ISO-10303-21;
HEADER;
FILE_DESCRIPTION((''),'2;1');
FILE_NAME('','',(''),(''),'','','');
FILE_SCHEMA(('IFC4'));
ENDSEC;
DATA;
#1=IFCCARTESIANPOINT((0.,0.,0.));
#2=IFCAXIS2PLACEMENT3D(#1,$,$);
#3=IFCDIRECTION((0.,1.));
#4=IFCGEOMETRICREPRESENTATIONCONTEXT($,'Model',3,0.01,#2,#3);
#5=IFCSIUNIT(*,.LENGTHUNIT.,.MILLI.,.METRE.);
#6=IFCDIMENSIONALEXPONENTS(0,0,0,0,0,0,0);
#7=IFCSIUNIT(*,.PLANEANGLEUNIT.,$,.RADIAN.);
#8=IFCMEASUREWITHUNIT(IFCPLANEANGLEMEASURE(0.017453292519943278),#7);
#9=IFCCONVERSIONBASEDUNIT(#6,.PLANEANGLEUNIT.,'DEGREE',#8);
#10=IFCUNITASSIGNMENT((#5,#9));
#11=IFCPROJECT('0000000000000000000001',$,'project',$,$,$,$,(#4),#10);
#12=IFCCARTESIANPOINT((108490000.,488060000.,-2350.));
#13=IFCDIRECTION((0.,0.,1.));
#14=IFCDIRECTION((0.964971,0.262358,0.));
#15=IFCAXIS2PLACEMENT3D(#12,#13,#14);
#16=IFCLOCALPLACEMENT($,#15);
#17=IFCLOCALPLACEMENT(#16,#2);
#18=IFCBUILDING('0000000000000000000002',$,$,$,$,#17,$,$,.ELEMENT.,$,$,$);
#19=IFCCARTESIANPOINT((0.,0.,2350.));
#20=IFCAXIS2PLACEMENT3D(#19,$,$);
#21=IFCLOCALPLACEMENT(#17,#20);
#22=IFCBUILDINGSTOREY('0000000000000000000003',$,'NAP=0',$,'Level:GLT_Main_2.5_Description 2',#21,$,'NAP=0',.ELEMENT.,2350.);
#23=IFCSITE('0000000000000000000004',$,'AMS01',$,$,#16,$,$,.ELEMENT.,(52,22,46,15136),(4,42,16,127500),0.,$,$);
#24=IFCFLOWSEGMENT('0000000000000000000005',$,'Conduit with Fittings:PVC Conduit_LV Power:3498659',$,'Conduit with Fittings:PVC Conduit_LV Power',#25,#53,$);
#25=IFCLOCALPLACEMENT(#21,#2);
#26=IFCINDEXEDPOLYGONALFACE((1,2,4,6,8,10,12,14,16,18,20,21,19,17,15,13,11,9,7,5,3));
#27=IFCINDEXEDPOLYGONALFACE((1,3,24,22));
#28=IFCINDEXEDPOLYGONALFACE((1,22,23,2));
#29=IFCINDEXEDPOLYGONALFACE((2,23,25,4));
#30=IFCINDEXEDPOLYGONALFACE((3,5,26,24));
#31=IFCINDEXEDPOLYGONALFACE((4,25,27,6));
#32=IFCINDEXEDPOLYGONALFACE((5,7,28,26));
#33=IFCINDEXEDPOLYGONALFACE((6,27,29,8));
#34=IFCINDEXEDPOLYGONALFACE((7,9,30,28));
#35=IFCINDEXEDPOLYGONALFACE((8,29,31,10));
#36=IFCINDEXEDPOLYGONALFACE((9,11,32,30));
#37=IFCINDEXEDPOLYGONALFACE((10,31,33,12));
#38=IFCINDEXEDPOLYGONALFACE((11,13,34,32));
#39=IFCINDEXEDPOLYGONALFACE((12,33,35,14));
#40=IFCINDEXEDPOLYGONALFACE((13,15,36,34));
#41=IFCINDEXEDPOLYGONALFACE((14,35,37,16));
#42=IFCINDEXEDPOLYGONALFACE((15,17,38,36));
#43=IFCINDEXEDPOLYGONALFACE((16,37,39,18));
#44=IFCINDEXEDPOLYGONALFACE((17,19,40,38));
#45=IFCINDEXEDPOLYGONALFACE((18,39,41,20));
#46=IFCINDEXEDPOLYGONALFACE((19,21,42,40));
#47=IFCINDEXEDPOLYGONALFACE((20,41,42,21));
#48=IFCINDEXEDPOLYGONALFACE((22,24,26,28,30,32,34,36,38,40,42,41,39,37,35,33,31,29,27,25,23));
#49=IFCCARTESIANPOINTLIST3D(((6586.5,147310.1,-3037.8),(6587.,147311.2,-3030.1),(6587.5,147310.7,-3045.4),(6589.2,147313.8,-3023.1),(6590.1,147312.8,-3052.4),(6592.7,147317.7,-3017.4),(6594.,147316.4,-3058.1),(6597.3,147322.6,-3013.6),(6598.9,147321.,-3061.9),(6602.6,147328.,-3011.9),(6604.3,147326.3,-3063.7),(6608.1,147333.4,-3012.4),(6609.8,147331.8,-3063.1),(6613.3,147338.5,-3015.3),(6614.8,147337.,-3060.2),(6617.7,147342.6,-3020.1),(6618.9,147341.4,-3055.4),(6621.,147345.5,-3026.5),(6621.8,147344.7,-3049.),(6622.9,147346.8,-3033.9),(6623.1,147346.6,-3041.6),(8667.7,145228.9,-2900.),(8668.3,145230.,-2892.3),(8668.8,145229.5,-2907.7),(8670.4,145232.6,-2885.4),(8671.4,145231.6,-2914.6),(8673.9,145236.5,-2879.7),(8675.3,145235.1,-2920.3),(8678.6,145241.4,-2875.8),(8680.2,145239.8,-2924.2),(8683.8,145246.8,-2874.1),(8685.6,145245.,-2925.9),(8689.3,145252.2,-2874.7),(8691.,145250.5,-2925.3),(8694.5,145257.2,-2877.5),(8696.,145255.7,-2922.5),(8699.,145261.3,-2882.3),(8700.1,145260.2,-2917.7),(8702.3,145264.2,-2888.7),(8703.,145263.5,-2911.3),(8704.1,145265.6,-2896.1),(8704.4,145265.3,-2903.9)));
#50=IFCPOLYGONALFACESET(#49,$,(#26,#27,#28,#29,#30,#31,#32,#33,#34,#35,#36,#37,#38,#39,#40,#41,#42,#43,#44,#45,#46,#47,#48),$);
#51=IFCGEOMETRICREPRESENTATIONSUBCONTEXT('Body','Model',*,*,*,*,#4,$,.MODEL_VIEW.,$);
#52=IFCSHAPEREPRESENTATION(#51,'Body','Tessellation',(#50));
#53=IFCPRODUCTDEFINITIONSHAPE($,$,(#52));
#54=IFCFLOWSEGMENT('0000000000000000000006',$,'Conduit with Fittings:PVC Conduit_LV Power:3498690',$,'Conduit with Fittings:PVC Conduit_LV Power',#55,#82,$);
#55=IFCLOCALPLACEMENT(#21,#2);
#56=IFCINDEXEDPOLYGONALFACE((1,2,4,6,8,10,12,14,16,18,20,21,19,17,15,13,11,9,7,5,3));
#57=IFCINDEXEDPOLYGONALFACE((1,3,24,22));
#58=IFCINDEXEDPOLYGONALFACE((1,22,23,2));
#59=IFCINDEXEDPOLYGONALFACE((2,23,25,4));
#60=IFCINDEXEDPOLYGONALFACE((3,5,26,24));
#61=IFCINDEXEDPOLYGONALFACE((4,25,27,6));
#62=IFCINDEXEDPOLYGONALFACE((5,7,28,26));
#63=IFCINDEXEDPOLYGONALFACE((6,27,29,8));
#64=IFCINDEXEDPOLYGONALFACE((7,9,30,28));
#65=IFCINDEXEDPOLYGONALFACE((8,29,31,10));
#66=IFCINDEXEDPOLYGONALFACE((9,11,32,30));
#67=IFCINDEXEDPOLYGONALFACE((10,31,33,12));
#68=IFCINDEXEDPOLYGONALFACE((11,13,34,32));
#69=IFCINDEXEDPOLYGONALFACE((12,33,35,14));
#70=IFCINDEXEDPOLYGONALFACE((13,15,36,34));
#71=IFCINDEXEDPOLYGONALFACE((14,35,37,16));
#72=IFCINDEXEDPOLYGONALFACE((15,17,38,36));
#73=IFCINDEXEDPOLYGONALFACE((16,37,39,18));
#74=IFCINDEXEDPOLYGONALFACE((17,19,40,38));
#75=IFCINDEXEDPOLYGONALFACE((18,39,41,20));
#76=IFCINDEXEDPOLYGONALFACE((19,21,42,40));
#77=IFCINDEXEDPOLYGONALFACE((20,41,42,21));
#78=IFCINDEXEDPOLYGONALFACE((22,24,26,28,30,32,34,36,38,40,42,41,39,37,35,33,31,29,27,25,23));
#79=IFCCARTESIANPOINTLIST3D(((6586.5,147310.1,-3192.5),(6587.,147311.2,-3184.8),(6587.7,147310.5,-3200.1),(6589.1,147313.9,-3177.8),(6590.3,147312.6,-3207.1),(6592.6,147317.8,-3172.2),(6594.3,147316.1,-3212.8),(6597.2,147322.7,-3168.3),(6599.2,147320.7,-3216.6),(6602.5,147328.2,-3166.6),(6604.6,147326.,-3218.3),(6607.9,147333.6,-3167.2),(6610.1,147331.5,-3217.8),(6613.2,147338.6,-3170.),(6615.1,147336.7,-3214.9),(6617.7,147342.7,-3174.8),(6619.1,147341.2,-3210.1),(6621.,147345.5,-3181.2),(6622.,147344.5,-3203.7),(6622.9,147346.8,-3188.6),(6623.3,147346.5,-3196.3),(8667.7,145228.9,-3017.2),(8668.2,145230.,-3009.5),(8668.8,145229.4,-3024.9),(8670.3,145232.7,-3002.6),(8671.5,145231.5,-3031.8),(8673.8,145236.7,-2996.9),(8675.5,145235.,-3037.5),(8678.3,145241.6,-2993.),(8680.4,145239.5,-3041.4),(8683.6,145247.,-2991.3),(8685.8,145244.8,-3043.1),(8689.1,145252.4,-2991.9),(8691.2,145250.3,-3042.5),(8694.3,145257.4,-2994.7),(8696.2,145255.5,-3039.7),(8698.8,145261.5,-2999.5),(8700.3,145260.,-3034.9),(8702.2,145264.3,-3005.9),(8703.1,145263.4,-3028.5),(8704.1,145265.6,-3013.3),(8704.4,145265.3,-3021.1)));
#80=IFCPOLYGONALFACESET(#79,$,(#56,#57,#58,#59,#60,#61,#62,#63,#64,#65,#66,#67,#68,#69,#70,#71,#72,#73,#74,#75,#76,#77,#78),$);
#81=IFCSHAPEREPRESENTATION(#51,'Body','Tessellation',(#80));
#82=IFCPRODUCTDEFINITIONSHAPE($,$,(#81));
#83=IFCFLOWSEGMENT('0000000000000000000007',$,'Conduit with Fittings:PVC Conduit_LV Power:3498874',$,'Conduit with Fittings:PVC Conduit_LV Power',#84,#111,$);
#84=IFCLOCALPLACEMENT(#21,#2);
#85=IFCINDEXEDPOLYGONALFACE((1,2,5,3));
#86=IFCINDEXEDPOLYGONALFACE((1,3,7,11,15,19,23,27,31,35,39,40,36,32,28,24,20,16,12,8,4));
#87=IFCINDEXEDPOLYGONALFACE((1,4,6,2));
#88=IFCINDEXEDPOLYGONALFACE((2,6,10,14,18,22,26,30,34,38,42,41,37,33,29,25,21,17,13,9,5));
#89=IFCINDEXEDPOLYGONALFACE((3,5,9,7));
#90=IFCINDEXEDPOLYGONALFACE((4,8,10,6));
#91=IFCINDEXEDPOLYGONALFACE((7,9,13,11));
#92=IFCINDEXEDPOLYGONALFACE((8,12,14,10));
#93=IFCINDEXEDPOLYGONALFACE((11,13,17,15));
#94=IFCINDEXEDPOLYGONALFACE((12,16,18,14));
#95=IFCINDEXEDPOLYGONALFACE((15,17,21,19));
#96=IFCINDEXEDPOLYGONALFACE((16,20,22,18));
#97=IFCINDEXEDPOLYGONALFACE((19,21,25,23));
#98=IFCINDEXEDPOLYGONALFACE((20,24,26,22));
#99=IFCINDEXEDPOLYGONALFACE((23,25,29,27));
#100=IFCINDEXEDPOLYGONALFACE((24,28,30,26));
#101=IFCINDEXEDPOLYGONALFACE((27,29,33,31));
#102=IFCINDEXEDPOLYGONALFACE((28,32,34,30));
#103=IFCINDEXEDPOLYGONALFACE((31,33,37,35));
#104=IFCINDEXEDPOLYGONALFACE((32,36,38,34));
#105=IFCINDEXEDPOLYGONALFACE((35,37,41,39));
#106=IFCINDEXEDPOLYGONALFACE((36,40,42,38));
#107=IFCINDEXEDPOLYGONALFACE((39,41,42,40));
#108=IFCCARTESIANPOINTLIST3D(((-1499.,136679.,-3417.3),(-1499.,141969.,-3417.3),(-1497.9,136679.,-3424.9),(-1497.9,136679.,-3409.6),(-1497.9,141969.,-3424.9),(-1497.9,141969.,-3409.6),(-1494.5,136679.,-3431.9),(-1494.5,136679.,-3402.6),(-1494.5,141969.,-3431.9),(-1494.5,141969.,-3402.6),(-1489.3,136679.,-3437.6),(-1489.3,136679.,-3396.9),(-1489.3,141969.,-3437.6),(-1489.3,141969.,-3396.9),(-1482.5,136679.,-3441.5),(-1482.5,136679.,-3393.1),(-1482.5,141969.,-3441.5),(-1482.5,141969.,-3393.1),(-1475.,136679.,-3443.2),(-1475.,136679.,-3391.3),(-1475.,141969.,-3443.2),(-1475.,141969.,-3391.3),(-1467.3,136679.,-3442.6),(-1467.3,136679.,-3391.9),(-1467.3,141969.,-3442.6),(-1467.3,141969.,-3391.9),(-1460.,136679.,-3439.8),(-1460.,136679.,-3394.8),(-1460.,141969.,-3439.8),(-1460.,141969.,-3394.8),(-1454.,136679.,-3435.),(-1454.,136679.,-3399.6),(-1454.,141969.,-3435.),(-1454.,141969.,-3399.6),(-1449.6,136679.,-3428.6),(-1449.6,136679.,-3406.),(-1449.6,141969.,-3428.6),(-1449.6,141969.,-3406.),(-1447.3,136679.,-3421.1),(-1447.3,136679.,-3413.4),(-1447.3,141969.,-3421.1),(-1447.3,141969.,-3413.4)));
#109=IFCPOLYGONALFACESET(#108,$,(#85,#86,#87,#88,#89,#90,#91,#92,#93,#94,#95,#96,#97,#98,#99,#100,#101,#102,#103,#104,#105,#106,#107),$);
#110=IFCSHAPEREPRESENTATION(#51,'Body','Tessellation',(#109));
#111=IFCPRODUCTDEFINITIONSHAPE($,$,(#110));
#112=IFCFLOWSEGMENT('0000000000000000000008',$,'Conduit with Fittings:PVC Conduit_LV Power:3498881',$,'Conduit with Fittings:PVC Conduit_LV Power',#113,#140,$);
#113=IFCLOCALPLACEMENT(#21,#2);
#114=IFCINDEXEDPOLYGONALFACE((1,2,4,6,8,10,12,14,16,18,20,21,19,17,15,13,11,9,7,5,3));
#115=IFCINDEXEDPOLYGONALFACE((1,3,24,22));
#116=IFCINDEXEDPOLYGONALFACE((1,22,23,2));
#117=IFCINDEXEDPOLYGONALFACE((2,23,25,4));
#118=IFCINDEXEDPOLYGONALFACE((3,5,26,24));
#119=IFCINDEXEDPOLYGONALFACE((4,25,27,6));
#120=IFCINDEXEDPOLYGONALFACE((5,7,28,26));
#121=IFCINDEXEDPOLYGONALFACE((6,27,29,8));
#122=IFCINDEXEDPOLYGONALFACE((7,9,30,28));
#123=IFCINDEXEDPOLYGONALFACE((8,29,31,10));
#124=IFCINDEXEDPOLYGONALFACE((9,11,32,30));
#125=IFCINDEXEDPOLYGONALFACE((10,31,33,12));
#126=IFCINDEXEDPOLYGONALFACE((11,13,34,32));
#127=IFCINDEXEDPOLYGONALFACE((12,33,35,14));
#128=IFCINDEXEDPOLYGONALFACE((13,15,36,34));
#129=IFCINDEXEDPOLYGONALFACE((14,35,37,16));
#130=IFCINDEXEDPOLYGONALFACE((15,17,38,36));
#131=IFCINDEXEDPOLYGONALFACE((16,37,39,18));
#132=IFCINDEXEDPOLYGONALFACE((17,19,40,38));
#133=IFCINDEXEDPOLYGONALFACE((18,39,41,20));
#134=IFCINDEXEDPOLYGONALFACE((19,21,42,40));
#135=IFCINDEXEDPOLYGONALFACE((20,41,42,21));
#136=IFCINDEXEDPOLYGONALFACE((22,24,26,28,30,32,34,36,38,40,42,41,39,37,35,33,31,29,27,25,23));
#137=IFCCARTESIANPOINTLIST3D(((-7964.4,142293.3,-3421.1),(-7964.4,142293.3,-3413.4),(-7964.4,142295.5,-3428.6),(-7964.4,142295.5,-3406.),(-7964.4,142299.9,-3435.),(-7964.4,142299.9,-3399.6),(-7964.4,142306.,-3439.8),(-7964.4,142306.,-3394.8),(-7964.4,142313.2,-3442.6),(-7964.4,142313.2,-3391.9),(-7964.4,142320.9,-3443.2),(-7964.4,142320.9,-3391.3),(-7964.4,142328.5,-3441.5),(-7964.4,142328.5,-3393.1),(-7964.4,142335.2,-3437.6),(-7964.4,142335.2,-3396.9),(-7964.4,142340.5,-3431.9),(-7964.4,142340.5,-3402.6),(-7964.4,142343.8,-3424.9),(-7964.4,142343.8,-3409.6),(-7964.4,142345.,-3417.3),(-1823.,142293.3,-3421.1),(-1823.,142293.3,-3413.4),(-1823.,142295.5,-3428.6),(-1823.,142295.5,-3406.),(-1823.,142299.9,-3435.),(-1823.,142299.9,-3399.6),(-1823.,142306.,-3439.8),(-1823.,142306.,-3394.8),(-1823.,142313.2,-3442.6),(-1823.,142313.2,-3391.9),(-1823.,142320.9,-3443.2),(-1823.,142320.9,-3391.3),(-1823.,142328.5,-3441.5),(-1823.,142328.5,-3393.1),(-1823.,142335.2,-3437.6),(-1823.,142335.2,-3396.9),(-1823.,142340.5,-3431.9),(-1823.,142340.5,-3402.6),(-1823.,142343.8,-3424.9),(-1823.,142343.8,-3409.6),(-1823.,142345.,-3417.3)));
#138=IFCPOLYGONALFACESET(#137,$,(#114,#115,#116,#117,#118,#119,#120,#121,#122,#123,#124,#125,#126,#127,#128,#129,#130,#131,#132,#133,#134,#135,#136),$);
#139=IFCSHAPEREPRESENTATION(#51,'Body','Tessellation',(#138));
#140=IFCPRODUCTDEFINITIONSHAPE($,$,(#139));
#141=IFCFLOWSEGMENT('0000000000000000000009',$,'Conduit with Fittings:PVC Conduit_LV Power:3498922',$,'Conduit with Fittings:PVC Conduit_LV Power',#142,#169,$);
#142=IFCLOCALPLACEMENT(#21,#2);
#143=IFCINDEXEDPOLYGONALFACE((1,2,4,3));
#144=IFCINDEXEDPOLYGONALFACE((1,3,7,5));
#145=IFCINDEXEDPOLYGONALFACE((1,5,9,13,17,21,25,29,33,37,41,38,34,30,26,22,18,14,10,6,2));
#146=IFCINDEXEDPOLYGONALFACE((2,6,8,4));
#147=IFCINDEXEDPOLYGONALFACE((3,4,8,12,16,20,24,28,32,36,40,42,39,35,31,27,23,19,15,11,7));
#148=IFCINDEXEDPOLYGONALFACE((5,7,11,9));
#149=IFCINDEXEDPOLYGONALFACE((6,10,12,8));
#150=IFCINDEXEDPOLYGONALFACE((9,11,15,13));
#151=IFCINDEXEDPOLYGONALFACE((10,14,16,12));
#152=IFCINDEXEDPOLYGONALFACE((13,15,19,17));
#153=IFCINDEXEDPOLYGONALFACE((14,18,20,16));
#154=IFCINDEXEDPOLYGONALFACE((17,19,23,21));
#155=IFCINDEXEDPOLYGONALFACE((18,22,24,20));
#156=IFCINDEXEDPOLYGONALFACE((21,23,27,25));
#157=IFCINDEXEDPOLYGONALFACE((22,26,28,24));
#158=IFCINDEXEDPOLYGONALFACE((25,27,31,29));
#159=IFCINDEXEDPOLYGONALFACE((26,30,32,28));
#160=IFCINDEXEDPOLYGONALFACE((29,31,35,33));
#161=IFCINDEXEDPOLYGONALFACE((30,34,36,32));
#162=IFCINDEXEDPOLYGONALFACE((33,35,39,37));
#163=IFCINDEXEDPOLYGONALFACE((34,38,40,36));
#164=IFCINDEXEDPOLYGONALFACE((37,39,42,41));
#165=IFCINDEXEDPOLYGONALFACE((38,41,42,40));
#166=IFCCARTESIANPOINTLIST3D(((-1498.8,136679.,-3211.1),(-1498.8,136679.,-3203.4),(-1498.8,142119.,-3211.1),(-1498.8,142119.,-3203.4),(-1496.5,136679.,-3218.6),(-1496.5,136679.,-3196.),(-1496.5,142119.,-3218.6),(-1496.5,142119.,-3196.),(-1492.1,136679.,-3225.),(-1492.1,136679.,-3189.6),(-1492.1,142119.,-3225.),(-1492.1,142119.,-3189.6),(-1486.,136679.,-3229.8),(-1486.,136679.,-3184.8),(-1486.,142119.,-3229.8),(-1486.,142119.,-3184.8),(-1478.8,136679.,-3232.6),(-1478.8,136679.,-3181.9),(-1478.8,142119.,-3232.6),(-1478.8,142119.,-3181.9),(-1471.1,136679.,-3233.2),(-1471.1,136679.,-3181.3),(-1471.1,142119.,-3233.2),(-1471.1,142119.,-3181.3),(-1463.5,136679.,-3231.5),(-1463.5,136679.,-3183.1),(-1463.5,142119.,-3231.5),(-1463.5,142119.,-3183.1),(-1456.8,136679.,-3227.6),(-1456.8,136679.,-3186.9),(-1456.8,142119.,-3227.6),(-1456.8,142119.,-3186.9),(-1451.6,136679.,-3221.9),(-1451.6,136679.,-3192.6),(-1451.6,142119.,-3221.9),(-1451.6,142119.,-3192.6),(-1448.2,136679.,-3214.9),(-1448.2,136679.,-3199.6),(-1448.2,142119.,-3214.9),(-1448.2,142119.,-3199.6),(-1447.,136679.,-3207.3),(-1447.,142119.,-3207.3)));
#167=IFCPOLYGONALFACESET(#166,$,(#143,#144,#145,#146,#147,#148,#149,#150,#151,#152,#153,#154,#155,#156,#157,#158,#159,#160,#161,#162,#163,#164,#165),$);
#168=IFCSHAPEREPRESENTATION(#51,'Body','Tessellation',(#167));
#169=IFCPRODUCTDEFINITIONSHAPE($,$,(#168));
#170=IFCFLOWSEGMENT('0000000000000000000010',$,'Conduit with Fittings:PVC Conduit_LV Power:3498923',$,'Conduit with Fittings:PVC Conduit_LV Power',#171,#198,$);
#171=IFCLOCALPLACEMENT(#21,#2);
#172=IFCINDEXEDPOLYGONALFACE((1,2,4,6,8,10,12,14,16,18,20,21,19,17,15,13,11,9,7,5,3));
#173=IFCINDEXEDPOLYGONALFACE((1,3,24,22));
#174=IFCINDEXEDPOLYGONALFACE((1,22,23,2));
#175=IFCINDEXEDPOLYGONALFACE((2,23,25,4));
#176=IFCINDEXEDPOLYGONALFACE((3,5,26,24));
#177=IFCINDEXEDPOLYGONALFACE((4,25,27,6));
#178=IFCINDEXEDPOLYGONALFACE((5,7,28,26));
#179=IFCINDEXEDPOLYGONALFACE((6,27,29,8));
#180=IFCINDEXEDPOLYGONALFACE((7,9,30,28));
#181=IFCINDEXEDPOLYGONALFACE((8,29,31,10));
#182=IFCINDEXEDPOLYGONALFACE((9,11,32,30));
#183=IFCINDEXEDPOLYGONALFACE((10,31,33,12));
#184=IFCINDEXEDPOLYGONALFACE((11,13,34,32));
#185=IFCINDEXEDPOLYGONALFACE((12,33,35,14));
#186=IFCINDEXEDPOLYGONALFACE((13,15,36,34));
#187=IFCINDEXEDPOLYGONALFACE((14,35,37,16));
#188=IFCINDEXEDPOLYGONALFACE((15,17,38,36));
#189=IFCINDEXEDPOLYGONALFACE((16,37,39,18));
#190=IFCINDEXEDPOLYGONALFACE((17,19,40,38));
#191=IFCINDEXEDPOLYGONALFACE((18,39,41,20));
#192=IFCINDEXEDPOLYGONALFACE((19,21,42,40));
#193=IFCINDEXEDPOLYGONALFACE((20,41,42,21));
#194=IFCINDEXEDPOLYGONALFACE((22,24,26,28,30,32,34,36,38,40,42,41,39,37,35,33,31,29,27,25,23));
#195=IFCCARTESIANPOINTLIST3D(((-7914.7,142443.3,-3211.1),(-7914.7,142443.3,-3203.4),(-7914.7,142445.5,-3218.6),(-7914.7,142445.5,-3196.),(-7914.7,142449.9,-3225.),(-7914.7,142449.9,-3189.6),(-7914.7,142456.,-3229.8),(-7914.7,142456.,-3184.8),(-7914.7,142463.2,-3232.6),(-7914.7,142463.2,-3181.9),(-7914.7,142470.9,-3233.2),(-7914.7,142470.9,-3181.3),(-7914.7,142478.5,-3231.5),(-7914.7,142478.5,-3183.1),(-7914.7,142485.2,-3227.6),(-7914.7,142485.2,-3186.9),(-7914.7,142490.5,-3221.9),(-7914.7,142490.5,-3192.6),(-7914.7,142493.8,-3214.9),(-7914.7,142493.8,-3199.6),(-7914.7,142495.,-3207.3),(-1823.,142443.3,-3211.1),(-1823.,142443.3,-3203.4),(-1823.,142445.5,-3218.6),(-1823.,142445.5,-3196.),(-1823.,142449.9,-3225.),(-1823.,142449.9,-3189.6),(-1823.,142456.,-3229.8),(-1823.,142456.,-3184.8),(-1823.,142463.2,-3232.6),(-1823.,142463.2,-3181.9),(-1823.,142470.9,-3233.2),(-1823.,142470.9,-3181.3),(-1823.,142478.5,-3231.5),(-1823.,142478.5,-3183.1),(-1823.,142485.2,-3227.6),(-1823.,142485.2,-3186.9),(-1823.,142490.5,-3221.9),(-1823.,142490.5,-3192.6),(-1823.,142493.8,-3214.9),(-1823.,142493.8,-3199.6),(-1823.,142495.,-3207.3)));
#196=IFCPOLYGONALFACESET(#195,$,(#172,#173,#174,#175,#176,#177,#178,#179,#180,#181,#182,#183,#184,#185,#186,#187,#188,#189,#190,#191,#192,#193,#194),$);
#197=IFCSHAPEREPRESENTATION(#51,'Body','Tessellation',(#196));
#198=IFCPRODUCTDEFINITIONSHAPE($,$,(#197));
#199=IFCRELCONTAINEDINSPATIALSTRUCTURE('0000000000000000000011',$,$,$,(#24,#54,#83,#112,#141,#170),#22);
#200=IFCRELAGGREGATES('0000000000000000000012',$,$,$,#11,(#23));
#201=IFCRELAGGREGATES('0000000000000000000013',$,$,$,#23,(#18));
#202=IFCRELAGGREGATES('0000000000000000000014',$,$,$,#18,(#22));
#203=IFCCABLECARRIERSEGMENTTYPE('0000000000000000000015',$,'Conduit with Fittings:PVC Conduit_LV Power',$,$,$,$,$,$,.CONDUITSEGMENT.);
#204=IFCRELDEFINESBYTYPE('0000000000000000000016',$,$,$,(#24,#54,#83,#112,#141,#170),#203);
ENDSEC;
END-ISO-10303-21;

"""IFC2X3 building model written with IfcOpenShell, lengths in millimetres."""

from ifc_helpers import new_model, entity, si_unit, converted_unit, direction, frame, frame_2d, origin, origin_2d_with_axis, place, context, subcontext, project, spatial, circle, extrude, type_object, element, save


model = new_model("IFC2X3")

# Units and contexts
model_context = context("Model", 3, precision=0.01, world=origin(), true_north=direction((0.0, 1.0)))
body_context = subcontext(model_context, "Body", "Model", "MODEL_VIEW")
ifc_project = project(units=[si_unit("LENGTHUNIT", "METRE", prefix="MILLI"), converted_unit("PLANEANGLEUNIT", "DEGREE", entity("IfcPlaneAngleMeasure", 0.017453292519943278), si_unit("PLANEANGLEUNIT", "RADIAN"), dimensions=[0, 0, 0, 0, 0, 0, 0])], contexts=[model_context])

# Site, building, storey
site_placement = place(None, frame((108490000.0, 488060000.0, -2350.0), z_axis=(0.0, 0.0, 1.0), x_axis=(0.964971, 0.262358, 0.0)))
site = spatial("IfcSite", under=ifc_project, at=site_placement, Name="AMS01", CompositionType="ELEMENT", RefLatitude=(52, 22, 46, 15136), RefLongitude=(4, 42, 16, 127500), RefElevation=0.0)
building_placement = place(site_placement, origin())
building = spatial("IfcBuilding", under=site, at=building_placement, CompositionType="ELEMENT")
storey_placement = place(building_placement, frame((0.0, 0.0, 2350.0)))
storey = spatial("IfcBuildingStorey", under=building, at=storey_placement, Name="NAP=0", ObjectType="Level:GLT_Main_2.5_Description 2", LongName="NAP=0", CompositionType="ELEMENT", Elevation=2350.0)

# Flow segments
cable_carrier_segment_type = type_object("IfcCableCarrierSegmentType", Name="Conduit with Fittings:PVC Conduit_LV Power", PredefinedType="CONDUITSEGMENT")
flow_segment_1_placement = place(storey_placement, origin())
element("IfcFlowSegment", 1, at=flow_segment_1_placement, inside=storey, type_object=cable_carrier_segment_type, Name="Conduit with Fittings:PVC Conduit_LV Power:3498659", ObjectType="Conduit with Fittings:PVC Conduit_LV Power", context=body_context, shape_type="SweptSolid", body=[
    extrude(circle(Radius=26.0, at=origin_2d_with_axis()), frame((6604.8, 147328.5, -3037.8), z_axis=(0.706334, -0.706334, 0.046751), x_axis=(-0.707107, -0.707107, 0.0)), (0.0, 0.0, 1.0), 2946.5),
])
flow_segment_2_placement = place(storey_placement, origin())
element("IfcFlowSegment", 2, at=flow_segment_2_placement, inside=storey, type_object=cable_carrier_segment_type, Name="Conduit with Fittings:PVC Conduit_LV Power:3498690", ObjectType="Conduit with Fittings:PVC Conduit_LV Power", context=body_context, shape_type="SweptSolid", body=[
    extrude(circle(Radius=26.0, at=frame_2d((0.0, 0.0), x_axis=(1.0, 0.0))), frame((6604.9, 147328.4, -3192.5), z_axis=(0.705856, -0.705856, 0.059444), x_axis=(-0.707107, -0.707107, 0.0)), (0.0, 0.0, 1.0), 2948.4),
])
flow_segment_3_placement = place(storey_placement, origin())
element("IfcFlowSegment", 3, at=flow_segment_3_placement, inside=storey, type_object=cable_carrier_segment_type, Name="Conduit with Fittings:PVC Conduit_LV Power:3498874", ObjectType="Conduit with Fittings:PVC Conduit_LV Power", context=body_context, shape_type="SweptSolid", body=[
    extrude(circle(Radius=26.0, at=frame_2d((0.0, 0.0), x_axis=(1.0, 0.0))), frame((-1473.0, 136679.0, -3417.3), z_axis=(0.0, 1.0, 0.0), x_axis=(-1.0, 0.0, 0.0)), (0.0, 0.0, 1.0), 5290.0),
])
flow_segment_4_placement = place(storey_placement, origin())
element("IfcFlowSegment", 4, at=flow_segment_4_placement, inside=storey, type_object=cable_carrier_segment_type, Name="Conduit with Fittings:PVC Conduit_LV Power:3498881", ObjectType="Conduit with Fittings:PVC Conduit_LV Power", context=body_context, shape_type="SweptSolid", body=[
    extrude(circle(Radius=26.0, at=frame_2d((0.0, 0.0), x_axis=(1.0, 0.0))), frame((-7964.4, 142319.0, -3417.3), z_axis=(1.0, 0.0, 0.0), x_axis=(0.0, 1.0, 0.0)), (0.0, 0.0, 1.0), 6141.3),
])
flow_segment_5_placement = place(storey_placement, origin())
element("IfcFlowSegment", 5, at=flow_segment_5_placement, inside=storey, type_object=cable_carrier_segment_type, Name="Conduit with Fittings:PVC Conduit_LV Power:3498922", ObjectType="Conduit with Fittings:PVC Conduit_LV Power", context=body_context, shape_type="SweptSolid", body=[
    extrude(circle(Radius=26.0, at=frame_2d((0.0, 0.0), x_axis=(1.0, 0.0))), frame((-1473.0, 136679.0, -3207.3), z_axis=(0.0, 1.0, 0.0), x_axis=(1.0, 0.0, 0.0)), (0.0, 0.0, 1.0), 5440.0),
])
flow_segment_6_placement = place(storey_placement, origin())
element("IfcFlowSegment", 6, at=flow_segment_6_placement, inside=storey, type_object=cable_carrier_segment_type, Name="Conduit with Fittings:PVC Conduit_LV Power:3498923", ObjectType="Conduit with Fittings:PVC Conduit_LV Power", context=body_context, shape_type="SweptSolid", body=[
    extrude(circle(Radius=26.0, at=frame_2d((0.0, 0.0), x_axis=(1.0, 0.0))), frame((-7914.7, 142469.0, -3207.3), z_axis=(1.0, 0.0, 0.0), x_axis=(0.0, 1.0, 0.0)), (0.0, 0.0, 1.0), 6091.7),
])

save(model, "model.ifc")
